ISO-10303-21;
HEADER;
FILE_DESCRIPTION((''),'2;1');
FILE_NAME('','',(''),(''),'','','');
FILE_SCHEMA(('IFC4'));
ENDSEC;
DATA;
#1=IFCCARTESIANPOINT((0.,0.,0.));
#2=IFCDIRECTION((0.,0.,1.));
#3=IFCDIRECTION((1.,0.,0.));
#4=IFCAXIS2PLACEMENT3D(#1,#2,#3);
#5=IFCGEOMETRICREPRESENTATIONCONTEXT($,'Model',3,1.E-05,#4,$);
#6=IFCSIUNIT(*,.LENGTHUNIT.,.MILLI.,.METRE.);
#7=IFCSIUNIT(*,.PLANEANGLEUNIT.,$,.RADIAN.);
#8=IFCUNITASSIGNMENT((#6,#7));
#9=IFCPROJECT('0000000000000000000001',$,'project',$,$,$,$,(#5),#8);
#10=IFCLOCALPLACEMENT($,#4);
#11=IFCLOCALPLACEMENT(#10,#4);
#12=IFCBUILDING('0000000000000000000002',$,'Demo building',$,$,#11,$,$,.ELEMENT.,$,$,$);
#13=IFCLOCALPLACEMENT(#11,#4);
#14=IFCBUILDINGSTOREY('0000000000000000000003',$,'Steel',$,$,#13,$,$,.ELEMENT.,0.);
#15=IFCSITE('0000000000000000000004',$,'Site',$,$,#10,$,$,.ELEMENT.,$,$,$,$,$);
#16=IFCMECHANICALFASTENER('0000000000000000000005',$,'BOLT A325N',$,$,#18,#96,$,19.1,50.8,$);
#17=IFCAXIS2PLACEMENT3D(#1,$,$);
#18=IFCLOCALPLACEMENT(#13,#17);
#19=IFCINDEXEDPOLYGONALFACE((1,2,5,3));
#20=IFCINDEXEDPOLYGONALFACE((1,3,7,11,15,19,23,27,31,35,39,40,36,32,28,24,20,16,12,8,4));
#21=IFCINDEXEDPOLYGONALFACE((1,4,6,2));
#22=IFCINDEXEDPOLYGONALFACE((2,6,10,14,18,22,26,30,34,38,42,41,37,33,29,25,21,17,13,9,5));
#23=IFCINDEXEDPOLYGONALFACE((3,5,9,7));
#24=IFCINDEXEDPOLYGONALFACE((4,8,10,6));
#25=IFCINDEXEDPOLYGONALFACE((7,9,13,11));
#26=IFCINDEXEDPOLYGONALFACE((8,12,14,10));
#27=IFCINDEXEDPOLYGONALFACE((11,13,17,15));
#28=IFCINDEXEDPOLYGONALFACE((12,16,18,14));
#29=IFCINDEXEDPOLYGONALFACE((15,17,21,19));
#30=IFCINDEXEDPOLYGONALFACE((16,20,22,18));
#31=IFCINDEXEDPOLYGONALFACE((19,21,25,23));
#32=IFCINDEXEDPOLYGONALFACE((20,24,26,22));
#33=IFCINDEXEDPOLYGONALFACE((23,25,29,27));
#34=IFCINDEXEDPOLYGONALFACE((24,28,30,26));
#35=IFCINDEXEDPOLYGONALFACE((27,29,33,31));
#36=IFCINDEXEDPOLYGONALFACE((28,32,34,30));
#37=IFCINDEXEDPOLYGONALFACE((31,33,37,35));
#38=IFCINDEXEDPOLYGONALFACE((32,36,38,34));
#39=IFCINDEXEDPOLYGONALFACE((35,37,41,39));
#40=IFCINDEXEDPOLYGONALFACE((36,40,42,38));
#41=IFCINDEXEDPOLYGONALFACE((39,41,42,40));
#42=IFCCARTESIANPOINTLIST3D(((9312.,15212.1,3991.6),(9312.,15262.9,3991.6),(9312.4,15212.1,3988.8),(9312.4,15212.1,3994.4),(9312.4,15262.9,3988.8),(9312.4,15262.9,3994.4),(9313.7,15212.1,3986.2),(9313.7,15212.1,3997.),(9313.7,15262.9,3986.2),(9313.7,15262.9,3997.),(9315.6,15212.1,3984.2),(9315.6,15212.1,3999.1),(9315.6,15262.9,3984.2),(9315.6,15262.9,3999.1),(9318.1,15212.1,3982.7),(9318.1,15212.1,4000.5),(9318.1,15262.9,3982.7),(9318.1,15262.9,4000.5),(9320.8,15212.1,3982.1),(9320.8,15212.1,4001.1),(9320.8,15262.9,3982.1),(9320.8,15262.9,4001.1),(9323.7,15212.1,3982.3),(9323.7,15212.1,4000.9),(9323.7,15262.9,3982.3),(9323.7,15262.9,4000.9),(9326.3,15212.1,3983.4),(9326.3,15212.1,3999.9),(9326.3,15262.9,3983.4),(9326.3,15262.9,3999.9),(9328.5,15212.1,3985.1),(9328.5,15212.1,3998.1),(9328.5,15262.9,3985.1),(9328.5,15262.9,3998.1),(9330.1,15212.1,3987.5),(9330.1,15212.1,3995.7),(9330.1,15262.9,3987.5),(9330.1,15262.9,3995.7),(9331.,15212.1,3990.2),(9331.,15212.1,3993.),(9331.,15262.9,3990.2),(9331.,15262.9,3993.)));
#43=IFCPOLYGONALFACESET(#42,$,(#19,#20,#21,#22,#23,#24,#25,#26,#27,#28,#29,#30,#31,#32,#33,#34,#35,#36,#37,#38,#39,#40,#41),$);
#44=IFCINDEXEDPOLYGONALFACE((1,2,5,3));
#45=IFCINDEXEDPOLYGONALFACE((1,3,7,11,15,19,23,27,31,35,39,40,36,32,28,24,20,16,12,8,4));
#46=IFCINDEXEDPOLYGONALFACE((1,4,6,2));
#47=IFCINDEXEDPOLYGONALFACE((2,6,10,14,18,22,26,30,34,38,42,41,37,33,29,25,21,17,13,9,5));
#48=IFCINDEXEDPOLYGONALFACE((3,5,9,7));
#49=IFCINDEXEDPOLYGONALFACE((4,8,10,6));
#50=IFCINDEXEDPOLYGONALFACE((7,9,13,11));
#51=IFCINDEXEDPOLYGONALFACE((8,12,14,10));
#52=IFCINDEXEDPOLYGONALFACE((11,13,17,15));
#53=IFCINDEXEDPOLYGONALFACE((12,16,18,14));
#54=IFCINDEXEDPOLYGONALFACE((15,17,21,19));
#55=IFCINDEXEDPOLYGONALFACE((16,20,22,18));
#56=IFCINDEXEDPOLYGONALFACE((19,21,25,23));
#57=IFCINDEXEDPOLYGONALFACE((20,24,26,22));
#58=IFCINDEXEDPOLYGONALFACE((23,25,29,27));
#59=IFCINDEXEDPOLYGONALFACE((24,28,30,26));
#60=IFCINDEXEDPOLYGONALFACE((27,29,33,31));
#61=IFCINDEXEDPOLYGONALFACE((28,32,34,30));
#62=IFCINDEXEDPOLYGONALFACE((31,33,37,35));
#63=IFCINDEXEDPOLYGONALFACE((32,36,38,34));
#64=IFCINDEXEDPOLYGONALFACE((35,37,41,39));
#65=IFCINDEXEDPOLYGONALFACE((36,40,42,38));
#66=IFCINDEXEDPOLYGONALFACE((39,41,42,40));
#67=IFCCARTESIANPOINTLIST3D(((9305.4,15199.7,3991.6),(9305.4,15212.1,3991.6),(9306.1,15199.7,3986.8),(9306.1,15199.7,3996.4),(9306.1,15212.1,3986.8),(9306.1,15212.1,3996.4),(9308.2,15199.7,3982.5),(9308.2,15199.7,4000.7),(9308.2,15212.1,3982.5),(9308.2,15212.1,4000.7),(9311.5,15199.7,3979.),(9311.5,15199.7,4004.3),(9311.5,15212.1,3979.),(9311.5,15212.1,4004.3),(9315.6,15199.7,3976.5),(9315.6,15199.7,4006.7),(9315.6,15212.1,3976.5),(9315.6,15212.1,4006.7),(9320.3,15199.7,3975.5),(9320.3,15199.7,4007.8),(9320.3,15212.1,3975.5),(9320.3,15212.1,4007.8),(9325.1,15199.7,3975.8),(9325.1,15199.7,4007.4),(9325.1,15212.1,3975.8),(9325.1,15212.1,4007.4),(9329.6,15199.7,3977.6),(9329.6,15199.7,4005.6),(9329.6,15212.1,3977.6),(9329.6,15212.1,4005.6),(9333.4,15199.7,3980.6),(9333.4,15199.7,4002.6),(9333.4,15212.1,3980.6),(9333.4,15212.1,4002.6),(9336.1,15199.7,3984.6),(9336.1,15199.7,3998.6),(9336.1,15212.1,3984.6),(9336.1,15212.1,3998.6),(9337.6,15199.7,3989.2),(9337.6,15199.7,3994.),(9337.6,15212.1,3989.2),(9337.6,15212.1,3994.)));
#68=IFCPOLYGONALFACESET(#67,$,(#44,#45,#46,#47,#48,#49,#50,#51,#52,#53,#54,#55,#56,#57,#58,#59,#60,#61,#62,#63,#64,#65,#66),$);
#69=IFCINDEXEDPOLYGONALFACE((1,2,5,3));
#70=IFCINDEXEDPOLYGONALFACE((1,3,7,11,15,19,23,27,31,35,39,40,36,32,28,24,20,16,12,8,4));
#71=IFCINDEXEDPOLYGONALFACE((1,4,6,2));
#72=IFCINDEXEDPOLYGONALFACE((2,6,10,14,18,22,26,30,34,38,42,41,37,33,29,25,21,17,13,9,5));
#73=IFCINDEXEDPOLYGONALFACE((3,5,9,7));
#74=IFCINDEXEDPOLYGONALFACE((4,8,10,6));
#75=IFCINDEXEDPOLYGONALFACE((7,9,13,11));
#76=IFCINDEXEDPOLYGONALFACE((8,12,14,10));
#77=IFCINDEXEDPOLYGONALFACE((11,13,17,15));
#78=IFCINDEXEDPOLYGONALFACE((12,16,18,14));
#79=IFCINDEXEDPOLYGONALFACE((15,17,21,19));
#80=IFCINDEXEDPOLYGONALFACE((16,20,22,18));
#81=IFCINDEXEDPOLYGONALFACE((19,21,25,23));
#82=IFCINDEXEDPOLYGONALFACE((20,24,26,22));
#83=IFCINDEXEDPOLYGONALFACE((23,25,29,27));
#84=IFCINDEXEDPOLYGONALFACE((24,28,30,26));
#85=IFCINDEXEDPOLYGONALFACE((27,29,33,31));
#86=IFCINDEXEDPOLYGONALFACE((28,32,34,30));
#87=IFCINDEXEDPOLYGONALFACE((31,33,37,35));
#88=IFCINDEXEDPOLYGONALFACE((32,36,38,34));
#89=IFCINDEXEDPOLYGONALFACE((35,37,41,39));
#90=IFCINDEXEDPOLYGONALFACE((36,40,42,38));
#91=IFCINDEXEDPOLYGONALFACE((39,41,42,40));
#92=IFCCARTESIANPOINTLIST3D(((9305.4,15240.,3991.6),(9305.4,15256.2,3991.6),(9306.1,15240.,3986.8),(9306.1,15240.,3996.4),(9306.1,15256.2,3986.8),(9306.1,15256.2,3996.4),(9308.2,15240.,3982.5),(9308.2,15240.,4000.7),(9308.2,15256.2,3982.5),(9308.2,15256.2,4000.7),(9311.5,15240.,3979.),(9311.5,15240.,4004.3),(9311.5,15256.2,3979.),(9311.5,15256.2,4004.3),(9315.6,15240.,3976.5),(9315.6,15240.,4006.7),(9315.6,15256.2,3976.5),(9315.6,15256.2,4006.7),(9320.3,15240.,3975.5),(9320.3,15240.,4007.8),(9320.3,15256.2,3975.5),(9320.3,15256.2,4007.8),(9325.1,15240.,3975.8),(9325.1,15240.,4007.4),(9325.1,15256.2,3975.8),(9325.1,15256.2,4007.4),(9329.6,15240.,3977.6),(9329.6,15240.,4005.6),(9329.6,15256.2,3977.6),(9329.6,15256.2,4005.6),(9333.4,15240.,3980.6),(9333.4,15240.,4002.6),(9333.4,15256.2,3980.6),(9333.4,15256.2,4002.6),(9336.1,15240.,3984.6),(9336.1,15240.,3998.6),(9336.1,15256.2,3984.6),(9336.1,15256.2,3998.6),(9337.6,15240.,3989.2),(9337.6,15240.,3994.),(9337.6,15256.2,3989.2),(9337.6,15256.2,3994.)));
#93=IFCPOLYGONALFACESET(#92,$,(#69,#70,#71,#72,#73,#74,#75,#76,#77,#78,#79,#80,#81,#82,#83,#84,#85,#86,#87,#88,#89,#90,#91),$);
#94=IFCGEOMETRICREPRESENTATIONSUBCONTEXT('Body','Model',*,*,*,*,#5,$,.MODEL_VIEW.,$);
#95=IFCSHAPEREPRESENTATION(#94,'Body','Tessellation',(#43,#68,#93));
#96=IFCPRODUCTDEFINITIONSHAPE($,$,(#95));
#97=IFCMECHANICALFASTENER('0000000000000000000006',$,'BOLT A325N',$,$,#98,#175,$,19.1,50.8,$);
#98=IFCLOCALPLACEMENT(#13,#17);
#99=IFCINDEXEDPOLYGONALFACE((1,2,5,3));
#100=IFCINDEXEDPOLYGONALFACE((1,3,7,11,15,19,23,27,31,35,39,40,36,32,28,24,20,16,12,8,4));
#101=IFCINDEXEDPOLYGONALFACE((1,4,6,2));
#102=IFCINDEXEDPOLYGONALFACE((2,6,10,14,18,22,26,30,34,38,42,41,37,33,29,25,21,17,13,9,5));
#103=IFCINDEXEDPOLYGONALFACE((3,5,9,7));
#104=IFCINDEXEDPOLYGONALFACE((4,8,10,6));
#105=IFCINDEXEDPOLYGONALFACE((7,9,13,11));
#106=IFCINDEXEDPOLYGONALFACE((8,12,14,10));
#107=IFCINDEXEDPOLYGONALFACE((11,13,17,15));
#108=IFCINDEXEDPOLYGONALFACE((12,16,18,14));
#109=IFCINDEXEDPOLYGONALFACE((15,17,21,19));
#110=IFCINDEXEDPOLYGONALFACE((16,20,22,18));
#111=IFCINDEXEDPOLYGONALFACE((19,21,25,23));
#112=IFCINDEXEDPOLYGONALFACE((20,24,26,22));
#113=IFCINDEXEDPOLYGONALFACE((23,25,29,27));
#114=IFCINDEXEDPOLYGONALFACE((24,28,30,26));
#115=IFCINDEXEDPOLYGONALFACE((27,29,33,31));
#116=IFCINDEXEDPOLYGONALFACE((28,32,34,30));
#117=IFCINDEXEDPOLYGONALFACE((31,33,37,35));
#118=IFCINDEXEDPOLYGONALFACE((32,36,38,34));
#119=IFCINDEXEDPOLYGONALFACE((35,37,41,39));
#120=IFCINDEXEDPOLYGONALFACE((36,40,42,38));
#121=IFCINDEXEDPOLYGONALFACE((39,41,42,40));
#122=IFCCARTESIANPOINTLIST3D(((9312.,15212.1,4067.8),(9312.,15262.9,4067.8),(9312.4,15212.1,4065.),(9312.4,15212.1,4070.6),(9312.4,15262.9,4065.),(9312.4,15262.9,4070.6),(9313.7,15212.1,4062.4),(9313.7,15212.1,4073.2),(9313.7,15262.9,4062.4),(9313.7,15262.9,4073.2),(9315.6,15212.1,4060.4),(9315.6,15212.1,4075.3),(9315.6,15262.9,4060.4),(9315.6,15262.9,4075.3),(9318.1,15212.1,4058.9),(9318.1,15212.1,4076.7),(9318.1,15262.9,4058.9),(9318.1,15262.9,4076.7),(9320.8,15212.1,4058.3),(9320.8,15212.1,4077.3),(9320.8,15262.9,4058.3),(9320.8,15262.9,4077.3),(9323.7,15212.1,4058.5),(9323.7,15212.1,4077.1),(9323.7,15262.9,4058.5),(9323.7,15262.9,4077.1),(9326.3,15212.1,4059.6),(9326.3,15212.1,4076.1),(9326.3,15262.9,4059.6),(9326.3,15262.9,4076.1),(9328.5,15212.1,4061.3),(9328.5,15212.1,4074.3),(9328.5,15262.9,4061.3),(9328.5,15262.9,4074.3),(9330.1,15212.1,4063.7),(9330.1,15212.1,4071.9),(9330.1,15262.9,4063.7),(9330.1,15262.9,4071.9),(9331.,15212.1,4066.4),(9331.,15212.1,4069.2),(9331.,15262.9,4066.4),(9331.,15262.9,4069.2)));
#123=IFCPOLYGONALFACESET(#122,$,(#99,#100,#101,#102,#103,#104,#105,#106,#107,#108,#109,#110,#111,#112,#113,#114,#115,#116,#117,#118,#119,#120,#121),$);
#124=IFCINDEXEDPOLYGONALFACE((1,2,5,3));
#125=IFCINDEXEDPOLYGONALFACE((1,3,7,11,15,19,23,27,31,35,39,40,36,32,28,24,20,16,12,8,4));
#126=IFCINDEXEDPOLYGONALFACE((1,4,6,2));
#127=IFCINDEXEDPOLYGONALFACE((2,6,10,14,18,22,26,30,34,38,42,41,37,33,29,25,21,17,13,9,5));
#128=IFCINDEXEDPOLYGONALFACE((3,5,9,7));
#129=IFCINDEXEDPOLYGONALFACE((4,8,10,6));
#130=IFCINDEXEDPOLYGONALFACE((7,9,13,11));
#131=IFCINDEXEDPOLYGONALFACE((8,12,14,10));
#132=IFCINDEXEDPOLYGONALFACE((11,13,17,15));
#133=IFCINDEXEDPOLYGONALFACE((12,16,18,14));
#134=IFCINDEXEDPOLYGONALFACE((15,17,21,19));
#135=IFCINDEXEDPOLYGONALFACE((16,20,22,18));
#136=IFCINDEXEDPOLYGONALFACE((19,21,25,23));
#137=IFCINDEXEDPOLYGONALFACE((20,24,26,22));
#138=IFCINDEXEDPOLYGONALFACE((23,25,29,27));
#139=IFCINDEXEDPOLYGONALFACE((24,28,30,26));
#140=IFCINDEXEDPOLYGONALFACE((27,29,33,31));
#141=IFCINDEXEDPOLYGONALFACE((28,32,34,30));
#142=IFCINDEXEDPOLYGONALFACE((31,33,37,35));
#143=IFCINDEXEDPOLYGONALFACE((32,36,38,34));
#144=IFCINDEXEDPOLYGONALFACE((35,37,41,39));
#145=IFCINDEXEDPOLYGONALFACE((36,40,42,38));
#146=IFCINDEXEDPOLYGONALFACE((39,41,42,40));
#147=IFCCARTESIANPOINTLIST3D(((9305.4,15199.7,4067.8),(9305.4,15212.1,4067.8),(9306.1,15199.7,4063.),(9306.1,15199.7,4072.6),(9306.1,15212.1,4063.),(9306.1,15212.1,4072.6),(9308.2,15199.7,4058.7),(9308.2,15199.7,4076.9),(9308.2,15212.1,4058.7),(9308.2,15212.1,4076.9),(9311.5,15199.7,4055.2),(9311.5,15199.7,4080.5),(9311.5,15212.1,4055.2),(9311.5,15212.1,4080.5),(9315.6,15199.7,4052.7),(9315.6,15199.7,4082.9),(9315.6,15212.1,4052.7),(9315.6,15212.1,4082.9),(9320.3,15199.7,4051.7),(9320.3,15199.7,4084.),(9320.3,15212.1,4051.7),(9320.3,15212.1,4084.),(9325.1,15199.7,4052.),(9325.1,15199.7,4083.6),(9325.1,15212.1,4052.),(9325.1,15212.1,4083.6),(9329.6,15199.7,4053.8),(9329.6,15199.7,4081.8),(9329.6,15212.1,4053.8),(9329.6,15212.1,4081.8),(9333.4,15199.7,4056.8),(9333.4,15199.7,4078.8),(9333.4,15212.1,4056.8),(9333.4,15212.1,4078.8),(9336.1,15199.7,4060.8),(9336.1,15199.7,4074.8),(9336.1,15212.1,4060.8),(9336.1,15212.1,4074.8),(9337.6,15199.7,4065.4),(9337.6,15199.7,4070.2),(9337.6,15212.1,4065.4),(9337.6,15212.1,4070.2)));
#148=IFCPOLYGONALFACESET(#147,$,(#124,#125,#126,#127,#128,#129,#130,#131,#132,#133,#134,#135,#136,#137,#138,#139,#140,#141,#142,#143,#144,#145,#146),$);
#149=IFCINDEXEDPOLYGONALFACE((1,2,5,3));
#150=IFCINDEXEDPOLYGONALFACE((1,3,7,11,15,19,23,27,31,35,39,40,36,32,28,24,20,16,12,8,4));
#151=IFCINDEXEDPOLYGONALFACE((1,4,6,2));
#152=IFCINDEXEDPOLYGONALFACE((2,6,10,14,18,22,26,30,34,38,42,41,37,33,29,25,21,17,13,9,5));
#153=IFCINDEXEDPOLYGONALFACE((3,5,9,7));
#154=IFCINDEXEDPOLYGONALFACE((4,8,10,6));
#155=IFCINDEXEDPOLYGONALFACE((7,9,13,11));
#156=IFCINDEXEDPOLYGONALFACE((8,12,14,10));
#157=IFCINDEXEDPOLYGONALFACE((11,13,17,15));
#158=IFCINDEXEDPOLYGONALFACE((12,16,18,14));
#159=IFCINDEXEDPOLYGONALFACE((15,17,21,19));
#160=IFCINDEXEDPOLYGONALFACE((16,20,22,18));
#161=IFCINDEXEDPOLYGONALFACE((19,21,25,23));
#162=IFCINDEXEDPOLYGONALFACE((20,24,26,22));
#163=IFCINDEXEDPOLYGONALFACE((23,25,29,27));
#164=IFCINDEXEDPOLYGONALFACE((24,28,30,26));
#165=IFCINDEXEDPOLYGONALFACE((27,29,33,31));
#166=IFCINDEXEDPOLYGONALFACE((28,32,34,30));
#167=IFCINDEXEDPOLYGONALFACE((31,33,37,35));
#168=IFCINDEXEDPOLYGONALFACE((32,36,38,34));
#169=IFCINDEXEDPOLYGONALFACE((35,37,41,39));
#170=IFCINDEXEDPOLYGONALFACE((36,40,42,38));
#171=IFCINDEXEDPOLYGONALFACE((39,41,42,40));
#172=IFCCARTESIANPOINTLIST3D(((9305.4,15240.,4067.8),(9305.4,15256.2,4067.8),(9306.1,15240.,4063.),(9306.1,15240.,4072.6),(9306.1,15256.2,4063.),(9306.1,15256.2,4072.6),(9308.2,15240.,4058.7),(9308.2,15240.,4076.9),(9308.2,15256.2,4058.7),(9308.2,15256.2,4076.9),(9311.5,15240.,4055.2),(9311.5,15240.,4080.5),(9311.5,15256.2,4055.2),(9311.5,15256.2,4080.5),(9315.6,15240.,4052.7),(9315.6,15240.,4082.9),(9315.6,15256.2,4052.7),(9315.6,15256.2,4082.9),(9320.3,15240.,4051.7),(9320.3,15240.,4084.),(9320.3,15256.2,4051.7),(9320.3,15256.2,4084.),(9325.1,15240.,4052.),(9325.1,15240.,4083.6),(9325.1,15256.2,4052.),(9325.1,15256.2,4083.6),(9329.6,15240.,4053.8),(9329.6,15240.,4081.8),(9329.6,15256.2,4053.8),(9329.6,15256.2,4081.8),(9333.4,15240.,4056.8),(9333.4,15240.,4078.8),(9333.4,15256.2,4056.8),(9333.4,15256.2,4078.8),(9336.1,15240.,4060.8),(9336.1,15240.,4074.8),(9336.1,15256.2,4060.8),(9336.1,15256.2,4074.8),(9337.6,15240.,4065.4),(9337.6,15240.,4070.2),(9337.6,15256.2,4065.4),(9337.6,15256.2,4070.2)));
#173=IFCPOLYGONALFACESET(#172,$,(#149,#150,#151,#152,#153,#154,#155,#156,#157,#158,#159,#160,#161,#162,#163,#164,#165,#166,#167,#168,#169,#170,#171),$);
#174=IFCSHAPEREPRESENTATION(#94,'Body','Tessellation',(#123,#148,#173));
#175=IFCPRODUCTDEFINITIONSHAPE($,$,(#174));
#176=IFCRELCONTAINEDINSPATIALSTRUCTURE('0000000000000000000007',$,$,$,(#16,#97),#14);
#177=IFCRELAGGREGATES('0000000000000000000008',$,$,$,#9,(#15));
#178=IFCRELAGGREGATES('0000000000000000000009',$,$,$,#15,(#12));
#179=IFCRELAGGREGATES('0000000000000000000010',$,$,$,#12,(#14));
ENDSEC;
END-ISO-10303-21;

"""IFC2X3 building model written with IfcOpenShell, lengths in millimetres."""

from ifc_helpers import new_model, si_unit, frame, origin, origin_with_axes, origin_2d, place, context, subcontext, project, spatial, circle, extrude, element, save


model = new_model("IFC2X3")

# Units and contexts
model_context = context("Model", 3, precision=1e-05, world=origin_with_axes())
body_context = subcontext(model_context, "Body", "Model", "MODEL_VIEW")
ifc_project = project(units=[si_unit("LENGTHUNIT", "METRE", prefix="MILLI"), si_unit("PLANEANGLEUNIT", "RADIAN")], contexts=[model_context])

# Site, building, storey
site_placement = place(None, origin_with_axes())
site = spatial("IfcSite", under=ifc_project, at=site_placement, Name="Site", CompositionType="ELEMENT")
building_placement = place(site_placement, origin_with_axes())
building = spatial("IfcBuilding", under=site, at=building_placement, Name="Demo building", CompositionType="ELEMENT")
placement = place(building_placement, origin_with_axes())
storey = spatial("IfcBuildingStorey", under=building, at=placement, Name="Steel", CompositionType="ELEMENT", Elevation=0.0)

# Mechanical fasteners
for number, where, z_axis, x_axis, name in (
    (1, (9321.5, 15212.1, 3991.6), (0.0, 1.0, 0.0), (-1.0, 0.0, 0.0), "BOLT A325N"),
    (2, (9321.5, 15212.1, 4067.8), (0.0, 1.0, 0.0), (-1.0, 0.0, 0.0), "BOLT A325N"),
):
    element("IfcMechanicalFastener", number, at=place(placement, frame(where, z_axis=z_axis, x_axis=x_axis)), inside=storey, Name=name, NominalDiameter=19.1, NominalLength=50.8, context=body_context, shape_type="SweptSolid", body=[
        extrude(circle(Radius=9.5, at=origin_2d()), origin(), (0.0, 0.0, 1.0), 50.8),
        extrude(circle(Radius=16.2, at=origin_2d()), frame((0.0, 0.0, -12.4)), (0.0, 0.0, 1.0), 12.4),
        extrude(circle(Radius=16.2, at=origin_2d()), frame((0.0, 0.0, 27.9)), (0.0, 0.0, 1.0), 16.2),
    ])

save(model, "model.ifc")
